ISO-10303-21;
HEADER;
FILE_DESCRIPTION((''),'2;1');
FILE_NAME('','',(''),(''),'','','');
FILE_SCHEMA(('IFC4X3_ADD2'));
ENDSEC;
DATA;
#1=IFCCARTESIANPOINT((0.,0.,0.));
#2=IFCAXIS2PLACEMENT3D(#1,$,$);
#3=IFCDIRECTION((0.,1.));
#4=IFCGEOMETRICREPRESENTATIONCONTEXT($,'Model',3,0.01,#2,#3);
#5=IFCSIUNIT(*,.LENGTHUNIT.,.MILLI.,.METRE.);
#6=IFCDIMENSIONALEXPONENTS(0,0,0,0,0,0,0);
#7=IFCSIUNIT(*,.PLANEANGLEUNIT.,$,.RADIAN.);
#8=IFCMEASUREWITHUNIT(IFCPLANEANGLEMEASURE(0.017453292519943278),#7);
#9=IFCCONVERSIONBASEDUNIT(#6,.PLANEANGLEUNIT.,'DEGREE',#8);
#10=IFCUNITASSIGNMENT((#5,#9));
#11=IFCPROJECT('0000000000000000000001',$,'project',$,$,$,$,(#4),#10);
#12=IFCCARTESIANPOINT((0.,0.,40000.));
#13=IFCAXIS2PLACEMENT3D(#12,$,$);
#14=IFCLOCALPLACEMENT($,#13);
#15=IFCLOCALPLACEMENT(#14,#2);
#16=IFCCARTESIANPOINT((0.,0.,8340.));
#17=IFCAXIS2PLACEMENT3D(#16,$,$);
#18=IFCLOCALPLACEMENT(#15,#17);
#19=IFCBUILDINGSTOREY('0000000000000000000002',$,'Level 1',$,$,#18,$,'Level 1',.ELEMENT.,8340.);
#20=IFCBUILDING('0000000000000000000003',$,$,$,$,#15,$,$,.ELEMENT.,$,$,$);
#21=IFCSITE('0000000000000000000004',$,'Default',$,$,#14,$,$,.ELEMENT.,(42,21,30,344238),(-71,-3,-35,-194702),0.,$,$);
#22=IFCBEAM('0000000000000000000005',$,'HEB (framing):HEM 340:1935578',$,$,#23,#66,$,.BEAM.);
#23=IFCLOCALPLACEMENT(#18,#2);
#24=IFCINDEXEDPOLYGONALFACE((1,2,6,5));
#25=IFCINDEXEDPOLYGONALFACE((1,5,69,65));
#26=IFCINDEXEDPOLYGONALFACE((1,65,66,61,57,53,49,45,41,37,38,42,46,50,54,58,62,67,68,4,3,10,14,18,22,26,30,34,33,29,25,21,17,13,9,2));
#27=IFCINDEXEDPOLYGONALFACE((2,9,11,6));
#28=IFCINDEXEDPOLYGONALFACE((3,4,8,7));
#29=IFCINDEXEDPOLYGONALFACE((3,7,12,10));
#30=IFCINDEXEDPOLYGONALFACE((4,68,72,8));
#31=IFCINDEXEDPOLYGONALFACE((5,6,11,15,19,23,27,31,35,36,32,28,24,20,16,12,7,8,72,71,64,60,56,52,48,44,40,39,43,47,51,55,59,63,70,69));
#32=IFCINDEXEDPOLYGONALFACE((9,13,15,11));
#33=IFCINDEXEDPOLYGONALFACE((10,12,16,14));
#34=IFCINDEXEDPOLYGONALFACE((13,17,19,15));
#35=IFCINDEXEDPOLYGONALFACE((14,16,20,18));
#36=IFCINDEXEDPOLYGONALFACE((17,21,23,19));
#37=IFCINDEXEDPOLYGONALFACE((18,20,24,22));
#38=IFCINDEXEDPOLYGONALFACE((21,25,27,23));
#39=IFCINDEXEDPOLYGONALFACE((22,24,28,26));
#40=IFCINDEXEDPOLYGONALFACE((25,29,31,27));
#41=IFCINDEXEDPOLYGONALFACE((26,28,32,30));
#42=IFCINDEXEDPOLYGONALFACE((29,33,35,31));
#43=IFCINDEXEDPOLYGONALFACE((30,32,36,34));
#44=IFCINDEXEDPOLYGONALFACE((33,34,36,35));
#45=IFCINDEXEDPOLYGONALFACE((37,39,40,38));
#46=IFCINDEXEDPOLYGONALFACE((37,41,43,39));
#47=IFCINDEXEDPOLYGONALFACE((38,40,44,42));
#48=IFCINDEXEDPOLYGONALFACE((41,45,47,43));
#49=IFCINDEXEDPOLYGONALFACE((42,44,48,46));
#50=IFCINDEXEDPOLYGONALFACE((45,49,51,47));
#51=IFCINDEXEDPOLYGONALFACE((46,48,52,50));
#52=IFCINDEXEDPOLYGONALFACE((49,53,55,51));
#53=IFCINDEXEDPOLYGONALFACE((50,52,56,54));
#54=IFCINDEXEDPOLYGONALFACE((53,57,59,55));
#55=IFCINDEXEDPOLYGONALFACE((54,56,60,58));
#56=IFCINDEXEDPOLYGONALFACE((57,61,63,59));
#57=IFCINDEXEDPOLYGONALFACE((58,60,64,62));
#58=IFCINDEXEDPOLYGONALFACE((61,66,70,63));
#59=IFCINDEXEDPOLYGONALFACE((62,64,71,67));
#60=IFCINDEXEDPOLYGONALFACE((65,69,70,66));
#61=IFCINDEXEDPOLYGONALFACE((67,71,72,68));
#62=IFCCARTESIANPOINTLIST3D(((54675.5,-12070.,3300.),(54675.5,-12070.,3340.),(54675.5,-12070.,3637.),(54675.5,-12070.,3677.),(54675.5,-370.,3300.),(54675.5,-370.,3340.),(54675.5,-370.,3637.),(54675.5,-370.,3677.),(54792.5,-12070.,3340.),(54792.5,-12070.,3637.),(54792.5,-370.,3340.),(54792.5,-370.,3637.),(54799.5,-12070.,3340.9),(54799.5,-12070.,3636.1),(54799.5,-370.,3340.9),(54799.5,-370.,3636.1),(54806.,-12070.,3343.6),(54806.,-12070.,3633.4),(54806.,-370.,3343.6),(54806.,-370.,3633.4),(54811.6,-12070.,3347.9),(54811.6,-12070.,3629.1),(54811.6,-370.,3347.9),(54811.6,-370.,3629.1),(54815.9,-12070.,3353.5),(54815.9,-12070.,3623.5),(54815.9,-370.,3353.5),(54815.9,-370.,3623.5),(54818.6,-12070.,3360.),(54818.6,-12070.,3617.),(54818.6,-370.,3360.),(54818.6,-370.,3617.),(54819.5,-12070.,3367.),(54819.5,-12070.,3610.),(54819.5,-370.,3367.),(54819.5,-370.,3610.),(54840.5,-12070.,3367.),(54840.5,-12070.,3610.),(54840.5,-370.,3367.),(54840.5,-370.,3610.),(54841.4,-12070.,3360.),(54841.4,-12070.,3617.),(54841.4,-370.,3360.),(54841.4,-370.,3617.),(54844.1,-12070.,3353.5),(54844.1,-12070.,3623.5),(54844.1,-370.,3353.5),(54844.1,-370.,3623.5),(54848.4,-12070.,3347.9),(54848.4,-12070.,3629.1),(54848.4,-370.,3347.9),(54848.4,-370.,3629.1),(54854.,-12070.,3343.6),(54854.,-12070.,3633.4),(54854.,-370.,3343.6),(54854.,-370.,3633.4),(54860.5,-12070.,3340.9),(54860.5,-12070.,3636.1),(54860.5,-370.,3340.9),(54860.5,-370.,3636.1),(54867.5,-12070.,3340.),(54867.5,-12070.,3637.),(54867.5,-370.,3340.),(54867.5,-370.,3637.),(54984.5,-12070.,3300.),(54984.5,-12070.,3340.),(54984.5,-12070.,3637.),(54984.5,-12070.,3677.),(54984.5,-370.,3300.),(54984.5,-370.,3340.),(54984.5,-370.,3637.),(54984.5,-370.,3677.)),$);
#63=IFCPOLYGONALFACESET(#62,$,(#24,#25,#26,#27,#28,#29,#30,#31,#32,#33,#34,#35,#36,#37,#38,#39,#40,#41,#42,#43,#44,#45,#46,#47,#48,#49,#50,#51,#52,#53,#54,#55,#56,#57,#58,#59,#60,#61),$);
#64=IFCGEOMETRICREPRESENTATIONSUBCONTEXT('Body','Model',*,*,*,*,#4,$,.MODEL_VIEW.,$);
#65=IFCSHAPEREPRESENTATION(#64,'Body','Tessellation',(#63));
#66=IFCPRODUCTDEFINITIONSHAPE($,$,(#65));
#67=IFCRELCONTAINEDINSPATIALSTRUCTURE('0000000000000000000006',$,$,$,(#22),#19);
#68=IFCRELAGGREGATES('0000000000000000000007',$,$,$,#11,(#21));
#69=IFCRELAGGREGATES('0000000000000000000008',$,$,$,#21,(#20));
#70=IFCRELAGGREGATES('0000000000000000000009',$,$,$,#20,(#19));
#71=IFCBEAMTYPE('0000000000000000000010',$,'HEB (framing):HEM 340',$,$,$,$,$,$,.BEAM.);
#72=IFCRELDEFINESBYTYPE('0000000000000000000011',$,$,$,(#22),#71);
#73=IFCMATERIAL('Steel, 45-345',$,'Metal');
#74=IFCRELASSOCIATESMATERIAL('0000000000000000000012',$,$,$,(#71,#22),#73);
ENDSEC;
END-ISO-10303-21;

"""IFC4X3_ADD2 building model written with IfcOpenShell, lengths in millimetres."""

from ifc_helpers import new_model, entity, si_unit, converted_unit, direction, frame, frame_2d, origin, place, context, subcontext, project, spatial, polyline, circle_curve, parameter, trimmed, segment, composite_curve, outline, extrude, source, transform, mapped, material, material_profile, profile_set, profile_usage, type_object, type_shapes, element, save


model = new_model("IFC4X3_ADD2")

# Units and contexts
model_context = context("Model", 3, precision=0.01, world=origin(), true_north=direction((0.0, 1.0)))
body_context = subcontext(model_context, "Body", "Model", "MODEL_VIEW")
ifc_project = project(units=[si_unit("LENGTHUNIT", "METRE", prefix="MILLI"), converted_unit("PLANEANGLEUNIT", "DEGREE", entity("IfcPlaneAngleMeasure", 0.017453292519943278), si_unit("PLANEANGLEUNIT", "RADIAN"), dimensions=[0, 0, 0, 0, 0, 0, 0])], contexts=[model_context])

# Site, building, storey
site_placement = place(None, frame((0.0, 0.0, 40000.0)))
site = spatial("IfcSite", under=ifc_project, at=site_placement, Name="Default", CompositionType="ELEMENT", RefLatitude=(42, 21, 30, 344238), RefLongitude=(-71, -3, -35, -194702), RefElevation=0.0)
building_placement = place(site_placement, origin())
building = spatial("IfcBuilding", under=site, at=building_placement, CompositionType="ELEMENT")
storey_placement = place(building_placement, frame((0.0, 0.0, 8340.0)))
storey = spatial("IfcBuildingStorey", under=building, at=storey_placement, Name="Level 1", LongName="Level 1", CompositionType="ELEMENT", Elevation=8340.0)

# Shared definitions
ifc_material = material(Name="Steel, 45-345", Category="Metal")

# Beam
ifc_material_profile_1 = material_profile(ifc_material, outline(composite_curve([segment(polyline([(-154.5, -148.5), (-154.5, -188.5)]), True, "CONTINUOUS"), segment(polyline([(-154.5, -188.5), (154.5, -188.5)]), True, "CONTINUOUS"), segment(polyline([(154.5, -188.5), (154.5, -148.5)]), True, "CONTINUOUS"), segment(polyline([(154.5, -148.5), (37.5, -148.5)]), True, "CONTINUOUS"), segment(trimmed(circle_curve(frame_2d((37.5, -121.5), x_axis=(1.0, 0.0)), 27.0), [parameter(180.0)], [parameter(270.0)], True, "PARAMETER"), False, "CONTINUOUS"), segment(polyline([(10.5, -121.5), (10.5, 121.5)]), True, "CONTINUOUS"), segment(trimmed(circle_curve(frame_2d((37.5, 121.5), x_axis=(1.0, 0.0)), 27.0), [parameter(90.0)], [parameter(180.0)], True, "PARAMETER"), False, "CONTINUOUS"), segment(polyline([(37.5, 148.5), (154.5, 148.5)]), True, "CONTINUOUS"), segment(polyline([(154.5, 148.5), (154.5, 188.5)]), True, "CONTINUOUS"), segment(polyline([(154.5, 188.5), (-154.5, 188.5)]), True, "CONTINUOUS"), segment(polyline([(-154.5, 188.5), (-154.5, 148.5)]), True, "CONTINUOUS"), segment(polyline([(-154.5, 148.5), (-37.5, 148.5)]), True, "CONTINUOUS"), segment(trimmed(circle_curve(frame_2d((-37.5, 121.5), x_axis=(1.0, 0.0)), 27.0), [parameter(360.0)], [parameter(90.0)], True, "PARAMETER"), False, "CONTINUOUS"), segment(polyline([(-10.5, 121.5), (-10.5, -121.5)]), True, "CONTINUOUS"), segment(trimmed(circle_curve(frame_2d((-37.5, -121.5), x_axis=(1.0, 0.0)), 27.0), [parameter(270.0)], [parameter(0.0)], True, "PARAMETER"), False, "CONTINUOUS"), segment(polyline([(-37.5, -148.5), (-154.5, -148.5)]), True, "CONTINUOUS")], self_intersect=False)), Name="HEM 340")
ifc_profile_set_1 = profile_set([ifc_material_profile_1], Name="HEM 340")
ifc_profile_usage_1 = profile_usage(ifc_profile_set_1, cardinal=8)
beam_type_1 = type_object("IfcBeamType", Name="HEB (framing):HEM 340", PredefinedType="BEAM", material=ifc_profile_set_1)
shared_shape_1 = source(origin(), body_context, "Body", "SweptSolid", [
    extrude(outline(composite_curve([segment(polyline([(-154.5, -148.5), (-154.5, -188.5)]), True, "CONTINUOUS"), segment(polyline([(-154.5, -188.5), (154.5, -188.5)]), True, "CONTINUOUS"), segment(polyline([(154.5, -188.5), (154.5, -148.5)]), True, "CONTINUOUS"), segment(polyline([(154.5, -148.5), (37.5, -148.5)]), True, "CONTINUOUS"), segment(trimmed(circle_curve(frame_2d((37.5, -121.5), x_axis=(1.0, 0.0)), 27.0), [parameter(180.0)], [parameter(270.0)], True, "PARAMETER"), False, "CONTINUOUS"), segment(polyline([(10.5, -121.5), (10.5, 121.5)]), True, "CONTINUOUS"), segment(trimmed(circle_curve(frame_2d((37.5, 121.5), x_axis=(1.0, 0.0)), 27.0), [parameter(90.0)], [parameter(180.0)], True, "PARAMETER"), False, "CONTINUOUS"), segment(polyline([(37.5, 148.5), (154.5, 148.5)]), True, "CONTINUOUS"), segment(polyline([(154.5, 148.5), (154.5, 188.5)]), True, "CONTINUOUS"), segment(polyline([(154.5, 188.5), (-154.5, 188.5)]), True, "CONTINUOUS"), segment(polyline([(-154.5, 188.5), (-154.5, 148.5)]), True, "CONTINUOUS"), segment(polyline([(-154.5, 148.5), (-37.5, 148.5)]), True, "CONTINUOUS"), segment(trimmed(circle_curve(frame_2d((-37.5, 121.5), x_axis=(1.0, 0.0)), 27.0), [parameter(360.0)], [parameter(90.0)], True, "PARAMETER"), False, "CONTINUOUS"), segment(polyline([(-10.5, 121.5), (-10.5, -121.5)]), True, "CONTINUOUS"), segment(trimmed(circle_curve(frame_2d((-37.5, -121.5), x_axis=(1.0, 0.0)), 27.0), [parameter(270.0)], [parameter(0.0)], True, "PARAMETER"), False, "CONTINUOUS"), segment(polyline([(-37.5, -148.5), (-154.5, -148.5)]), True, "CONTINUOUS")], self_intersect=False)), frame((-5850.0, 0.0, 0.0), z_axis=(-1.0, 0.0, 0.0), x_axis=(0.0, -1.0, 0.0)), (0.0, 0.0, -1.0), 11700.0),
])
type_shapes(beam_type_1, [shared_shape_1])
beam_1_placement = place(storey_placement, frame((54830.0, -6220.0, 3488.5), z_axis=(0.0, 0.0, 1.0), x_axis=(0.0, -1.0, 0.0)))
element("IfcBeam", 1, at=beam_1_placement, inside=storey, type_object=beam_type_1, material=ifc_profile_usage_1, Name="HEB (framing):HEM 340:1935578", PredefinedType="BEAM", context=body_context, shape_type="MappedRepresentation", body=[
    mapped(shared_shape_1, transform((0.0, 0.0, 0.0), scale=1.0)),
])

save(model, "model.ifc")
